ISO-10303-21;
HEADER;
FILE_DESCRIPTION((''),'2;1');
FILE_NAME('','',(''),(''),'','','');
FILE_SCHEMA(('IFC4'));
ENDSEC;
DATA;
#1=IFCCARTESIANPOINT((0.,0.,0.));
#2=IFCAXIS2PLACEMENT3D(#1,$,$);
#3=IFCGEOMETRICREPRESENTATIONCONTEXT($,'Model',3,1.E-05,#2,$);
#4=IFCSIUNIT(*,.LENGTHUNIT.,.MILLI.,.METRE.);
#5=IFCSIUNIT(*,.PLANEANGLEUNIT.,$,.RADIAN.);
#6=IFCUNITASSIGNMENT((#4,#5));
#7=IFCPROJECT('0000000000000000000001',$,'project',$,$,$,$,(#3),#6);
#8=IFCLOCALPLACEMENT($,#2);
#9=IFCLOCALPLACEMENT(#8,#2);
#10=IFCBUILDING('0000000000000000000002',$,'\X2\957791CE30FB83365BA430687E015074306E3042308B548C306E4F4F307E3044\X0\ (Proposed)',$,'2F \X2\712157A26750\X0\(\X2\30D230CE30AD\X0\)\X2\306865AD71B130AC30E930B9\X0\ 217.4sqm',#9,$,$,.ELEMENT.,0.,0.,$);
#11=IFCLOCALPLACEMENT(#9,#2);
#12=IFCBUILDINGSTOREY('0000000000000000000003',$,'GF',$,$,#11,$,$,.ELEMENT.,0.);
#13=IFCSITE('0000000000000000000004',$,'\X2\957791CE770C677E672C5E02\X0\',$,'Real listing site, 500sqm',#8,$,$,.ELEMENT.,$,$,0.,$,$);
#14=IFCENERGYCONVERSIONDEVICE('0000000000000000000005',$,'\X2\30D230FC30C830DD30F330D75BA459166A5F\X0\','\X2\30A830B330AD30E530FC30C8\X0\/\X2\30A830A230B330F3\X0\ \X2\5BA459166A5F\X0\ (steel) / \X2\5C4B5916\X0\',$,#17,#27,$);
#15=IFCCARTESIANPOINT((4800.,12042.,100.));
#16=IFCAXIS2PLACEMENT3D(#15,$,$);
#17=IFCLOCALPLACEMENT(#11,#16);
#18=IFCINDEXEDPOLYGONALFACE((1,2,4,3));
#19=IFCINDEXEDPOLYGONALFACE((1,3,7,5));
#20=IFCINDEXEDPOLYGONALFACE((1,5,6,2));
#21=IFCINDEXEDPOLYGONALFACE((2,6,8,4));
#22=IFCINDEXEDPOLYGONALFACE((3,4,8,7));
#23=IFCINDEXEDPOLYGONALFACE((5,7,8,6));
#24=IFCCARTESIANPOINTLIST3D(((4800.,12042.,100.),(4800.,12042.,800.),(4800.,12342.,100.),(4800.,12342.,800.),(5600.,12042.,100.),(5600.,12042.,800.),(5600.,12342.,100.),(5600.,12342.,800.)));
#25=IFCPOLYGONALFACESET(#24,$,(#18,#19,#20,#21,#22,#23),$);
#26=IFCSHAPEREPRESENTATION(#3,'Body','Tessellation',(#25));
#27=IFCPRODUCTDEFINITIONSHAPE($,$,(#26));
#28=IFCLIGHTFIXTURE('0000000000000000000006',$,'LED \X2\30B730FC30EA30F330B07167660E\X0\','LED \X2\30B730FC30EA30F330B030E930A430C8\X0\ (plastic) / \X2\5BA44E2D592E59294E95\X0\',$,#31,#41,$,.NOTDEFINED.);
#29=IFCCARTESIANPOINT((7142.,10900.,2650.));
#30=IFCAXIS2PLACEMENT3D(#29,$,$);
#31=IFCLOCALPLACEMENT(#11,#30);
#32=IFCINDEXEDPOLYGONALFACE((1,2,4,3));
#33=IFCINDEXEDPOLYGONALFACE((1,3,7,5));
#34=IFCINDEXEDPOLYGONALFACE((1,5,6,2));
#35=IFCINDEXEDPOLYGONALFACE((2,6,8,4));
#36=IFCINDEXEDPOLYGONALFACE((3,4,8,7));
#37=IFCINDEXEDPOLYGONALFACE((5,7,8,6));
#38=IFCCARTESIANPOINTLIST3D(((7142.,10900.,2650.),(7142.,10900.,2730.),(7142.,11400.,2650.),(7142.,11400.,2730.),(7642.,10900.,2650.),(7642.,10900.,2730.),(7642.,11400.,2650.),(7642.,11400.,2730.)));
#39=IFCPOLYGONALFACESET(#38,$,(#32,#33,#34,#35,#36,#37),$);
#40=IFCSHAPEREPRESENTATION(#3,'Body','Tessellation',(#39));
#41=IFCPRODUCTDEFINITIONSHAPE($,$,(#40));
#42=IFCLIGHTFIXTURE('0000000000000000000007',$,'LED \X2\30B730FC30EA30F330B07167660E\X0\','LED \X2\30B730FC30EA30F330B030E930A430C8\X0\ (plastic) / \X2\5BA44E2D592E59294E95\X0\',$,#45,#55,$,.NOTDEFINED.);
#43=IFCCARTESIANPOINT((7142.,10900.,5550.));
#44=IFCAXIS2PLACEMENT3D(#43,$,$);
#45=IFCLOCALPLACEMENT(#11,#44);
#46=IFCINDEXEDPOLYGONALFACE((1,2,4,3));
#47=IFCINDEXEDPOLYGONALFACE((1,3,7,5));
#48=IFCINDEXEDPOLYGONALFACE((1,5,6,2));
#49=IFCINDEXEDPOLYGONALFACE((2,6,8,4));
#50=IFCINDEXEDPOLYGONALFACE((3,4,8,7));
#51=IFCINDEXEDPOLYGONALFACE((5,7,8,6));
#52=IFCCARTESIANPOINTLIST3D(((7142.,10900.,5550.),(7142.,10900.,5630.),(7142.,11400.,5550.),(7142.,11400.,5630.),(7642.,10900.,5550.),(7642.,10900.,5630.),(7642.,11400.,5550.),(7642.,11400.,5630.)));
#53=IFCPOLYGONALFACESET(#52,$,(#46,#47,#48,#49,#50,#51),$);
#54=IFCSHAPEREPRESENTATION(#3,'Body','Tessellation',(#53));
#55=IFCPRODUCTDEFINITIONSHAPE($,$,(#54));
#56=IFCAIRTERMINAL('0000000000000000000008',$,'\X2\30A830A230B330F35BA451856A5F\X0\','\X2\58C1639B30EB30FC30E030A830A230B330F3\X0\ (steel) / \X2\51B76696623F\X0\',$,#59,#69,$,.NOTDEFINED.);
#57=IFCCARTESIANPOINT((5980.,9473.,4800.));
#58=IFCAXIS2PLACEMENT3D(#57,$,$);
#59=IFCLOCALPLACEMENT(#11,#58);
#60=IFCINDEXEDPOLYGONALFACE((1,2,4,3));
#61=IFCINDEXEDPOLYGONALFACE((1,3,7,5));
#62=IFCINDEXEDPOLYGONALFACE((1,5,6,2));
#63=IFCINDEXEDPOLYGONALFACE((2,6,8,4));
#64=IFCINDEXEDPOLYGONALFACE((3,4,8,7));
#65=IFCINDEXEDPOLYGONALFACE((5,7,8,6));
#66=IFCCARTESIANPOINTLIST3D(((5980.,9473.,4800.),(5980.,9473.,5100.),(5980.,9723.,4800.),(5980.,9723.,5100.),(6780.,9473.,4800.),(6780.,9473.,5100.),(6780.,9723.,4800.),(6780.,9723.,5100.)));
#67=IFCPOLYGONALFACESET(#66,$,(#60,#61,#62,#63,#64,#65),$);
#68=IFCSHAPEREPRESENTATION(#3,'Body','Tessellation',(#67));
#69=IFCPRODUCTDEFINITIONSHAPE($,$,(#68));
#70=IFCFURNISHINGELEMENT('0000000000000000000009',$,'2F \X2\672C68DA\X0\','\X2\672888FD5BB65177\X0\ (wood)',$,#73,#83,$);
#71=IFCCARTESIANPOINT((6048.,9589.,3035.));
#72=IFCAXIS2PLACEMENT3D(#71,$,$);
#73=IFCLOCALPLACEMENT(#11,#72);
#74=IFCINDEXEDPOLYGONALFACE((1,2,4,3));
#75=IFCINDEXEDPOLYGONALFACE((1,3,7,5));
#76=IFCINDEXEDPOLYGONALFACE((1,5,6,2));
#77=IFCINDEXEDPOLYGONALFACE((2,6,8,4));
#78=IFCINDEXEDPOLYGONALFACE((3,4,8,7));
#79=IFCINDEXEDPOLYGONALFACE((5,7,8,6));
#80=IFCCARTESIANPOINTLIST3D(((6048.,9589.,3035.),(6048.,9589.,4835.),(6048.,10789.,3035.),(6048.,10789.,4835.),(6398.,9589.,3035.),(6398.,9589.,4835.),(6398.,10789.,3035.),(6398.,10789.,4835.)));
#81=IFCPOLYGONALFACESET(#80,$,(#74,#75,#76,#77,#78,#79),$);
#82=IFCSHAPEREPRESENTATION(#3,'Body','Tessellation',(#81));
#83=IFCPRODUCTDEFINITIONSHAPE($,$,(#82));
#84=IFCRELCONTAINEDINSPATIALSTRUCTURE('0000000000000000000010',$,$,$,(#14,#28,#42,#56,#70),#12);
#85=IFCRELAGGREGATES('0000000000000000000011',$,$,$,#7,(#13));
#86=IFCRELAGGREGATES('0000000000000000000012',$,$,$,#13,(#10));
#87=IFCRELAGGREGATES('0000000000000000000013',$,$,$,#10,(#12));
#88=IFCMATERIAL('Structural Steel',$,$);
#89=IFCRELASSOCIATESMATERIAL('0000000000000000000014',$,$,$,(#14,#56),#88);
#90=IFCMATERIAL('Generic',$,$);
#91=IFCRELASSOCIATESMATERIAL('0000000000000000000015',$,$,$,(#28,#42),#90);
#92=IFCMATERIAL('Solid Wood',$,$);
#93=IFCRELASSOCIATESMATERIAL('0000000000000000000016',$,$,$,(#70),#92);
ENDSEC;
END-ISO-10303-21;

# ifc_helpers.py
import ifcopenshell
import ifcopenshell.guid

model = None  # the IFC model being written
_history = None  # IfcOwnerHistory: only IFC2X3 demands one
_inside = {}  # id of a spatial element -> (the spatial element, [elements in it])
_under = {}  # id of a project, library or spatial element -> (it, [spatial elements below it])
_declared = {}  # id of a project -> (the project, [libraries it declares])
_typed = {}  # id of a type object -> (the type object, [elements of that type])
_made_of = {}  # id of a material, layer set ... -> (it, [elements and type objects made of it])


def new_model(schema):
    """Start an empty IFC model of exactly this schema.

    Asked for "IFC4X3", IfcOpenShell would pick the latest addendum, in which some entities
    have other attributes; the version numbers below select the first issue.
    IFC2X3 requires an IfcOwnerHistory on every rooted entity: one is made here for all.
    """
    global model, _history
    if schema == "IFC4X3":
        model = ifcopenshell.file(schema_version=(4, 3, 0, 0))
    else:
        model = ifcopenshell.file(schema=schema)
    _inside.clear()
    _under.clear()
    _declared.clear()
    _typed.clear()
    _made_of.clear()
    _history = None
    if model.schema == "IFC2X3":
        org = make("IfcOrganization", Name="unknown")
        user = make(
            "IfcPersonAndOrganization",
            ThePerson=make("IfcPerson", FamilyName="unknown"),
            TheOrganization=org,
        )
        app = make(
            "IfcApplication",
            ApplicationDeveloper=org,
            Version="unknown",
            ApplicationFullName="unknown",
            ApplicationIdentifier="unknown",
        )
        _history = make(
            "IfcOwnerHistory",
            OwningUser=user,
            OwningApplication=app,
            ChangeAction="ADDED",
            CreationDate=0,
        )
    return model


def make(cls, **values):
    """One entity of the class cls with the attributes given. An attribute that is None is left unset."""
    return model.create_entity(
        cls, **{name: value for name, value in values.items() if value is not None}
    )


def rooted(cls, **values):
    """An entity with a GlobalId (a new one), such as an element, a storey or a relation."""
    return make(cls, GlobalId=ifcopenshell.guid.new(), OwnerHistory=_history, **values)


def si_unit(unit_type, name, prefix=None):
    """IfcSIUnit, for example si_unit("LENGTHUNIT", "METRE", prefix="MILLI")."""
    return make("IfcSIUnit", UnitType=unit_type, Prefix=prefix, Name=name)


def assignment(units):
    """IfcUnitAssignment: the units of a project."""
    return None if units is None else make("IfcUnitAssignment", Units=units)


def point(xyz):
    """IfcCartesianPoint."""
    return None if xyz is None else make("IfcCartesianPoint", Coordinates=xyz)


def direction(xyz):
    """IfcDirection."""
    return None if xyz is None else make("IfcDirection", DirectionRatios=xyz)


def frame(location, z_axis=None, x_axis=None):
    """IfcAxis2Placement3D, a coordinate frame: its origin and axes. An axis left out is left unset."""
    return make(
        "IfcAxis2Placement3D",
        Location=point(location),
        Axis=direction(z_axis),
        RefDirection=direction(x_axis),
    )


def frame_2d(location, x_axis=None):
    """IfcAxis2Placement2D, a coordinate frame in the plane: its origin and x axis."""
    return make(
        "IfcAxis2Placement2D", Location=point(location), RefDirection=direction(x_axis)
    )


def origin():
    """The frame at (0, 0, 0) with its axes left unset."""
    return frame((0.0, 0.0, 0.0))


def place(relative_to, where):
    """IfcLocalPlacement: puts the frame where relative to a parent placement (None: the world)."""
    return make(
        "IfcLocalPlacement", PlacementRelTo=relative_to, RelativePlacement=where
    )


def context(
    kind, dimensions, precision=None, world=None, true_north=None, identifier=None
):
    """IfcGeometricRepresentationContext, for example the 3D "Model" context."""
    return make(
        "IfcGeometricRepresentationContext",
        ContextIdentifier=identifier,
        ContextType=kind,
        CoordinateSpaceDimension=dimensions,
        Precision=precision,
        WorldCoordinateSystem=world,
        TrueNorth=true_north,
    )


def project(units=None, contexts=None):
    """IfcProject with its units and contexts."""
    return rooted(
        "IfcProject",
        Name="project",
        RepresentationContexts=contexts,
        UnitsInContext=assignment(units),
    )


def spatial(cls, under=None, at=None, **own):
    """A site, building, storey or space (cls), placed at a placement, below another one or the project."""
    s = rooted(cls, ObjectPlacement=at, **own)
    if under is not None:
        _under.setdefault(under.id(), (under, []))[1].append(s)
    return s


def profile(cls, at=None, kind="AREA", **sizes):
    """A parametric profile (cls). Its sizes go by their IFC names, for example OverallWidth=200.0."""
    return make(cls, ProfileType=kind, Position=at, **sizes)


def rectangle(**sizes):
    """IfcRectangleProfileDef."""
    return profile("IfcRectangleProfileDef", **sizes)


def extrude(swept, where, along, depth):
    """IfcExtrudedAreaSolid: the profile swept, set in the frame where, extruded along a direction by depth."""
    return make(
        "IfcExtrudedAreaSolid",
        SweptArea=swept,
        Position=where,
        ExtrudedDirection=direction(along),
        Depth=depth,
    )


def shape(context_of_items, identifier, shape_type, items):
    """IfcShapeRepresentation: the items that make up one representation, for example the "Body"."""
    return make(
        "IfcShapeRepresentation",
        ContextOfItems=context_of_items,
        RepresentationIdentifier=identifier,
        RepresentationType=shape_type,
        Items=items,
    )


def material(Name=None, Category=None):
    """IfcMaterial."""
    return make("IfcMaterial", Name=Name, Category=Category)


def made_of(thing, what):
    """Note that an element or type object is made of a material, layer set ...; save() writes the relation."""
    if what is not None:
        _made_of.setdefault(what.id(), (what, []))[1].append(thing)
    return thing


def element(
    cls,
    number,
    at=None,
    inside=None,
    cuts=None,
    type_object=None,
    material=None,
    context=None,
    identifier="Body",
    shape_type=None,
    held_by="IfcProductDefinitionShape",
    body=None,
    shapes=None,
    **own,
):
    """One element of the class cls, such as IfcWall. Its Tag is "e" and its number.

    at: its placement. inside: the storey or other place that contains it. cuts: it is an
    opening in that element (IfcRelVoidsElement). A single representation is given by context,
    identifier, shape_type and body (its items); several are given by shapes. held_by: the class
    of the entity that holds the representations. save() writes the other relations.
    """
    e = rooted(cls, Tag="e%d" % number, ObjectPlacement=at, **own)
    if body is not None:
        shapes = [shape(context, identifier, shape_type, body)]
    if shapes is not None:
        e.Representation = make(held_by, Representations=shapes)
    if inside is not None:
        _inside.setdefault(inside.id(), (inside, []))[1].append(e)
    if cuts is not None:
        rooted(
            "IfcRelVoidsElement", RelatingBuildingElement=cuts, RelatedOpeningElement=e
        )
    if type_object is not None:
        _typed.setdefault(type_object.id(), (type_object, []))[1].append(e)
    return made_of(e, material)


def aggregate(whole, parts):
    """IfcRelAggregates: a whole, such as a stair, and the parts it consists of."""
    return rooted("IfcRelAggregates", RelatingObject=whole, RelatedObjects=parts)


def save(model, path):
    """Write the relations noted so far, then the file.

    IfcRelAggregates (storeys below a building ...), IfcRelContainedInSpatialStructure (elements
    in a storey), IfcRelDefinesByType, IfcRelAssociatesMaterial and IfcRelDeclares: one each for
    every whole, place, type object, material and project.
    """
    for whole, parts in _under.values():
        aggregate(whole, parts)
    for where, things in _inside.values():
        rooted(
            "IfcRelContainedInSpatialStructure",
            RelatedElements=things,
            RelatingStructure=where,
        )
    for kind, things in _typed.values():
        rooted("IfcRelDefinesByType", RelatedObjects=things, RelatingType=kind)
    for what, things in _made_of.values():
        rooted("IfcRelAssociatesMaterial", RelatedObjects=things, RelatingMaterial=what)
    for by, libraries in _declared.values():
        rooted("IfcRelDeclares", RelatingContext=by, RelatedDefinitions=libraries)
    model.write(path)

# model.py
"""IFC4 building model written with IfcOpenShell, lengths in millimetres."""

from ifc_helpers import new_model, si_unit, frame, frame_2d, origin, place, context, project, spatial, rectangle, extrude, material, element, save


model = new_model("IFC4")

# Units and contexts
model_context = context("Model", 3, precision=1e-05, world=origin())
ifc_project = project(units=[si_unit("LENGTHUNIT", "METRE", prefix="MILLI"), si_unit("PLANEANGLEUNIT", "RADIAN")], contexts=[model_context])

# Site, building, storey
site_placement = place(None, origin())
site = spatial("IfcSite", under=ifc_project, at=site_placement, Name="長野県松本市", ObjectType="Real listing site, 500sqm", CompositionType="ELEMENT", RefElevation=0.0)
building_placement = place(site_placement, origin())
building = spatial("IfcBuilding", under=site, at=building_placement, Name="長野・茶室と縁側のある和の住まい (Proposed)", ObjectType="2F 無垢材(ヒノキ)と断熱ガラス 217.4sqm", CompositionType="ELEMENT", ElevationOfRefHeight=0.0, ElevationOfTerrain=0.0)
storey_placement = place(building_placement, origin())
storey = spatial("IfcBuildingStorey", under=building, at=storey_placement, Name="GF", CompositionType="ELEMENT", Elevation=0.0)

# Shared definitions
ifc_material_1 = material(Name="Solid Wood")

# Shared definitions
ifc_material_2 = material(Name="Structural Steel")

# Shared definitions
ifc_material_3 = material(Name="Generic")

# Energy conversion device
energy_conversion_device_placement = place(storey_placement, frame((4800.0, 12042.0, 100.0)))
element("IfcEnergyConversionDevice", 1, at=energy_conversion_device_placement, inside=storey, material=ifc_material_2, Name="ヒートポンプ室外機", Description="エコキュート/エアコン 室外機 (steel) / 屋外", context=model_context, shape_type="SweptSolid", body=[
    extrude(rectangle(XDim=800.0, YDim=300.0, at=frame_2d((400.0, 150.0))), frame((4800.0, 12042.0, 100.0)), (0.0, 0.0, 1.0), 700.0),
])

# Light fixtures
light_fixture_1_placement = place(storey_placement, frame((7142.0, 10900.0, 2650.0)))
element("IfcLightFixture", 2, at=light_fixture_1_placement, inside=storey, material=ifc_material_3, Name="LED シーリング照明", Description="LED シーリングライト (plastic) / 室中央天井", PredefinedType="NOTDEFINED", context=model_context, shape_type="SweptSolid", body=[
    extrude(rectangle(XDim=500.0, YDim=500.0, at=frame_2d((250.0, 250.0))), frame((7142.0, 10900.0, 2650.0)), (0.0, 0.0, 1.0), 80.0),
])
light_fixture_2_placement = place(storey_placement, frame((7142.0, 10900.0, 5550.0)))
element("IfcLightFixture", 3, at=light_fixture_2_placement, inside=storey, material=ifc_material_3, Name="LED シーリング照明", Description="LED シーリングライト (plastic) / 室中央天井", PredefinedType="NOTDEFINED", context=model_context, shape_type="SweptSolid", body=[
    extrude(rectangle(XDim=500.0, YDim=500.0, at=frame_2d((250.0, 250.0))), frame((7142.0, 10900.0, 5550.0)), (0.0, 0.0, 1.0), 80.0),
])

# Air terminal
air_terminal_placement = place(storey_placement, frame((5980.0, 9473.0, 4800.0)))
element("IfcAirTerminal", 4, at=air_terminal_placement, inside=storey, material=ifc_material_2, Name="エアコン室内機", Description="壁掛ルームエアコン (steel) / 冷暖房", PredefinedType="NOTDEFINED", context=model_context, shape_type="SweptSolid", body=[
    extrude(rectangle(XDim=800.0, YDim=250.0, at=frame_2d((400.0, 125.0))), frame((5980.0, 9473.0, 4800.0)), (0.0, 0.0, 1.0), 300.0),
])

# Furnishing element
furnishing_placement = place(storey_placement, frame((6048.0, 9589.0, 3035.0)))
element("IfcFurnishingElement", 5, at=furnishing_placement, inside=storey, material=ifc_material_1, Name="2F 本棚", Description="木製家具 (wood)", context=model_context, shape_type="SweptSolid", body=[
    extrude(rectangle(XDim=350.0, YDim=1200.0, at=frame_2d((175.0, 600.0))), frame((6048.0, 9589.0, 3035.0)), (0.0, 0.0, 1.0), 1800.0),
])

save(model, "model.ifc")
